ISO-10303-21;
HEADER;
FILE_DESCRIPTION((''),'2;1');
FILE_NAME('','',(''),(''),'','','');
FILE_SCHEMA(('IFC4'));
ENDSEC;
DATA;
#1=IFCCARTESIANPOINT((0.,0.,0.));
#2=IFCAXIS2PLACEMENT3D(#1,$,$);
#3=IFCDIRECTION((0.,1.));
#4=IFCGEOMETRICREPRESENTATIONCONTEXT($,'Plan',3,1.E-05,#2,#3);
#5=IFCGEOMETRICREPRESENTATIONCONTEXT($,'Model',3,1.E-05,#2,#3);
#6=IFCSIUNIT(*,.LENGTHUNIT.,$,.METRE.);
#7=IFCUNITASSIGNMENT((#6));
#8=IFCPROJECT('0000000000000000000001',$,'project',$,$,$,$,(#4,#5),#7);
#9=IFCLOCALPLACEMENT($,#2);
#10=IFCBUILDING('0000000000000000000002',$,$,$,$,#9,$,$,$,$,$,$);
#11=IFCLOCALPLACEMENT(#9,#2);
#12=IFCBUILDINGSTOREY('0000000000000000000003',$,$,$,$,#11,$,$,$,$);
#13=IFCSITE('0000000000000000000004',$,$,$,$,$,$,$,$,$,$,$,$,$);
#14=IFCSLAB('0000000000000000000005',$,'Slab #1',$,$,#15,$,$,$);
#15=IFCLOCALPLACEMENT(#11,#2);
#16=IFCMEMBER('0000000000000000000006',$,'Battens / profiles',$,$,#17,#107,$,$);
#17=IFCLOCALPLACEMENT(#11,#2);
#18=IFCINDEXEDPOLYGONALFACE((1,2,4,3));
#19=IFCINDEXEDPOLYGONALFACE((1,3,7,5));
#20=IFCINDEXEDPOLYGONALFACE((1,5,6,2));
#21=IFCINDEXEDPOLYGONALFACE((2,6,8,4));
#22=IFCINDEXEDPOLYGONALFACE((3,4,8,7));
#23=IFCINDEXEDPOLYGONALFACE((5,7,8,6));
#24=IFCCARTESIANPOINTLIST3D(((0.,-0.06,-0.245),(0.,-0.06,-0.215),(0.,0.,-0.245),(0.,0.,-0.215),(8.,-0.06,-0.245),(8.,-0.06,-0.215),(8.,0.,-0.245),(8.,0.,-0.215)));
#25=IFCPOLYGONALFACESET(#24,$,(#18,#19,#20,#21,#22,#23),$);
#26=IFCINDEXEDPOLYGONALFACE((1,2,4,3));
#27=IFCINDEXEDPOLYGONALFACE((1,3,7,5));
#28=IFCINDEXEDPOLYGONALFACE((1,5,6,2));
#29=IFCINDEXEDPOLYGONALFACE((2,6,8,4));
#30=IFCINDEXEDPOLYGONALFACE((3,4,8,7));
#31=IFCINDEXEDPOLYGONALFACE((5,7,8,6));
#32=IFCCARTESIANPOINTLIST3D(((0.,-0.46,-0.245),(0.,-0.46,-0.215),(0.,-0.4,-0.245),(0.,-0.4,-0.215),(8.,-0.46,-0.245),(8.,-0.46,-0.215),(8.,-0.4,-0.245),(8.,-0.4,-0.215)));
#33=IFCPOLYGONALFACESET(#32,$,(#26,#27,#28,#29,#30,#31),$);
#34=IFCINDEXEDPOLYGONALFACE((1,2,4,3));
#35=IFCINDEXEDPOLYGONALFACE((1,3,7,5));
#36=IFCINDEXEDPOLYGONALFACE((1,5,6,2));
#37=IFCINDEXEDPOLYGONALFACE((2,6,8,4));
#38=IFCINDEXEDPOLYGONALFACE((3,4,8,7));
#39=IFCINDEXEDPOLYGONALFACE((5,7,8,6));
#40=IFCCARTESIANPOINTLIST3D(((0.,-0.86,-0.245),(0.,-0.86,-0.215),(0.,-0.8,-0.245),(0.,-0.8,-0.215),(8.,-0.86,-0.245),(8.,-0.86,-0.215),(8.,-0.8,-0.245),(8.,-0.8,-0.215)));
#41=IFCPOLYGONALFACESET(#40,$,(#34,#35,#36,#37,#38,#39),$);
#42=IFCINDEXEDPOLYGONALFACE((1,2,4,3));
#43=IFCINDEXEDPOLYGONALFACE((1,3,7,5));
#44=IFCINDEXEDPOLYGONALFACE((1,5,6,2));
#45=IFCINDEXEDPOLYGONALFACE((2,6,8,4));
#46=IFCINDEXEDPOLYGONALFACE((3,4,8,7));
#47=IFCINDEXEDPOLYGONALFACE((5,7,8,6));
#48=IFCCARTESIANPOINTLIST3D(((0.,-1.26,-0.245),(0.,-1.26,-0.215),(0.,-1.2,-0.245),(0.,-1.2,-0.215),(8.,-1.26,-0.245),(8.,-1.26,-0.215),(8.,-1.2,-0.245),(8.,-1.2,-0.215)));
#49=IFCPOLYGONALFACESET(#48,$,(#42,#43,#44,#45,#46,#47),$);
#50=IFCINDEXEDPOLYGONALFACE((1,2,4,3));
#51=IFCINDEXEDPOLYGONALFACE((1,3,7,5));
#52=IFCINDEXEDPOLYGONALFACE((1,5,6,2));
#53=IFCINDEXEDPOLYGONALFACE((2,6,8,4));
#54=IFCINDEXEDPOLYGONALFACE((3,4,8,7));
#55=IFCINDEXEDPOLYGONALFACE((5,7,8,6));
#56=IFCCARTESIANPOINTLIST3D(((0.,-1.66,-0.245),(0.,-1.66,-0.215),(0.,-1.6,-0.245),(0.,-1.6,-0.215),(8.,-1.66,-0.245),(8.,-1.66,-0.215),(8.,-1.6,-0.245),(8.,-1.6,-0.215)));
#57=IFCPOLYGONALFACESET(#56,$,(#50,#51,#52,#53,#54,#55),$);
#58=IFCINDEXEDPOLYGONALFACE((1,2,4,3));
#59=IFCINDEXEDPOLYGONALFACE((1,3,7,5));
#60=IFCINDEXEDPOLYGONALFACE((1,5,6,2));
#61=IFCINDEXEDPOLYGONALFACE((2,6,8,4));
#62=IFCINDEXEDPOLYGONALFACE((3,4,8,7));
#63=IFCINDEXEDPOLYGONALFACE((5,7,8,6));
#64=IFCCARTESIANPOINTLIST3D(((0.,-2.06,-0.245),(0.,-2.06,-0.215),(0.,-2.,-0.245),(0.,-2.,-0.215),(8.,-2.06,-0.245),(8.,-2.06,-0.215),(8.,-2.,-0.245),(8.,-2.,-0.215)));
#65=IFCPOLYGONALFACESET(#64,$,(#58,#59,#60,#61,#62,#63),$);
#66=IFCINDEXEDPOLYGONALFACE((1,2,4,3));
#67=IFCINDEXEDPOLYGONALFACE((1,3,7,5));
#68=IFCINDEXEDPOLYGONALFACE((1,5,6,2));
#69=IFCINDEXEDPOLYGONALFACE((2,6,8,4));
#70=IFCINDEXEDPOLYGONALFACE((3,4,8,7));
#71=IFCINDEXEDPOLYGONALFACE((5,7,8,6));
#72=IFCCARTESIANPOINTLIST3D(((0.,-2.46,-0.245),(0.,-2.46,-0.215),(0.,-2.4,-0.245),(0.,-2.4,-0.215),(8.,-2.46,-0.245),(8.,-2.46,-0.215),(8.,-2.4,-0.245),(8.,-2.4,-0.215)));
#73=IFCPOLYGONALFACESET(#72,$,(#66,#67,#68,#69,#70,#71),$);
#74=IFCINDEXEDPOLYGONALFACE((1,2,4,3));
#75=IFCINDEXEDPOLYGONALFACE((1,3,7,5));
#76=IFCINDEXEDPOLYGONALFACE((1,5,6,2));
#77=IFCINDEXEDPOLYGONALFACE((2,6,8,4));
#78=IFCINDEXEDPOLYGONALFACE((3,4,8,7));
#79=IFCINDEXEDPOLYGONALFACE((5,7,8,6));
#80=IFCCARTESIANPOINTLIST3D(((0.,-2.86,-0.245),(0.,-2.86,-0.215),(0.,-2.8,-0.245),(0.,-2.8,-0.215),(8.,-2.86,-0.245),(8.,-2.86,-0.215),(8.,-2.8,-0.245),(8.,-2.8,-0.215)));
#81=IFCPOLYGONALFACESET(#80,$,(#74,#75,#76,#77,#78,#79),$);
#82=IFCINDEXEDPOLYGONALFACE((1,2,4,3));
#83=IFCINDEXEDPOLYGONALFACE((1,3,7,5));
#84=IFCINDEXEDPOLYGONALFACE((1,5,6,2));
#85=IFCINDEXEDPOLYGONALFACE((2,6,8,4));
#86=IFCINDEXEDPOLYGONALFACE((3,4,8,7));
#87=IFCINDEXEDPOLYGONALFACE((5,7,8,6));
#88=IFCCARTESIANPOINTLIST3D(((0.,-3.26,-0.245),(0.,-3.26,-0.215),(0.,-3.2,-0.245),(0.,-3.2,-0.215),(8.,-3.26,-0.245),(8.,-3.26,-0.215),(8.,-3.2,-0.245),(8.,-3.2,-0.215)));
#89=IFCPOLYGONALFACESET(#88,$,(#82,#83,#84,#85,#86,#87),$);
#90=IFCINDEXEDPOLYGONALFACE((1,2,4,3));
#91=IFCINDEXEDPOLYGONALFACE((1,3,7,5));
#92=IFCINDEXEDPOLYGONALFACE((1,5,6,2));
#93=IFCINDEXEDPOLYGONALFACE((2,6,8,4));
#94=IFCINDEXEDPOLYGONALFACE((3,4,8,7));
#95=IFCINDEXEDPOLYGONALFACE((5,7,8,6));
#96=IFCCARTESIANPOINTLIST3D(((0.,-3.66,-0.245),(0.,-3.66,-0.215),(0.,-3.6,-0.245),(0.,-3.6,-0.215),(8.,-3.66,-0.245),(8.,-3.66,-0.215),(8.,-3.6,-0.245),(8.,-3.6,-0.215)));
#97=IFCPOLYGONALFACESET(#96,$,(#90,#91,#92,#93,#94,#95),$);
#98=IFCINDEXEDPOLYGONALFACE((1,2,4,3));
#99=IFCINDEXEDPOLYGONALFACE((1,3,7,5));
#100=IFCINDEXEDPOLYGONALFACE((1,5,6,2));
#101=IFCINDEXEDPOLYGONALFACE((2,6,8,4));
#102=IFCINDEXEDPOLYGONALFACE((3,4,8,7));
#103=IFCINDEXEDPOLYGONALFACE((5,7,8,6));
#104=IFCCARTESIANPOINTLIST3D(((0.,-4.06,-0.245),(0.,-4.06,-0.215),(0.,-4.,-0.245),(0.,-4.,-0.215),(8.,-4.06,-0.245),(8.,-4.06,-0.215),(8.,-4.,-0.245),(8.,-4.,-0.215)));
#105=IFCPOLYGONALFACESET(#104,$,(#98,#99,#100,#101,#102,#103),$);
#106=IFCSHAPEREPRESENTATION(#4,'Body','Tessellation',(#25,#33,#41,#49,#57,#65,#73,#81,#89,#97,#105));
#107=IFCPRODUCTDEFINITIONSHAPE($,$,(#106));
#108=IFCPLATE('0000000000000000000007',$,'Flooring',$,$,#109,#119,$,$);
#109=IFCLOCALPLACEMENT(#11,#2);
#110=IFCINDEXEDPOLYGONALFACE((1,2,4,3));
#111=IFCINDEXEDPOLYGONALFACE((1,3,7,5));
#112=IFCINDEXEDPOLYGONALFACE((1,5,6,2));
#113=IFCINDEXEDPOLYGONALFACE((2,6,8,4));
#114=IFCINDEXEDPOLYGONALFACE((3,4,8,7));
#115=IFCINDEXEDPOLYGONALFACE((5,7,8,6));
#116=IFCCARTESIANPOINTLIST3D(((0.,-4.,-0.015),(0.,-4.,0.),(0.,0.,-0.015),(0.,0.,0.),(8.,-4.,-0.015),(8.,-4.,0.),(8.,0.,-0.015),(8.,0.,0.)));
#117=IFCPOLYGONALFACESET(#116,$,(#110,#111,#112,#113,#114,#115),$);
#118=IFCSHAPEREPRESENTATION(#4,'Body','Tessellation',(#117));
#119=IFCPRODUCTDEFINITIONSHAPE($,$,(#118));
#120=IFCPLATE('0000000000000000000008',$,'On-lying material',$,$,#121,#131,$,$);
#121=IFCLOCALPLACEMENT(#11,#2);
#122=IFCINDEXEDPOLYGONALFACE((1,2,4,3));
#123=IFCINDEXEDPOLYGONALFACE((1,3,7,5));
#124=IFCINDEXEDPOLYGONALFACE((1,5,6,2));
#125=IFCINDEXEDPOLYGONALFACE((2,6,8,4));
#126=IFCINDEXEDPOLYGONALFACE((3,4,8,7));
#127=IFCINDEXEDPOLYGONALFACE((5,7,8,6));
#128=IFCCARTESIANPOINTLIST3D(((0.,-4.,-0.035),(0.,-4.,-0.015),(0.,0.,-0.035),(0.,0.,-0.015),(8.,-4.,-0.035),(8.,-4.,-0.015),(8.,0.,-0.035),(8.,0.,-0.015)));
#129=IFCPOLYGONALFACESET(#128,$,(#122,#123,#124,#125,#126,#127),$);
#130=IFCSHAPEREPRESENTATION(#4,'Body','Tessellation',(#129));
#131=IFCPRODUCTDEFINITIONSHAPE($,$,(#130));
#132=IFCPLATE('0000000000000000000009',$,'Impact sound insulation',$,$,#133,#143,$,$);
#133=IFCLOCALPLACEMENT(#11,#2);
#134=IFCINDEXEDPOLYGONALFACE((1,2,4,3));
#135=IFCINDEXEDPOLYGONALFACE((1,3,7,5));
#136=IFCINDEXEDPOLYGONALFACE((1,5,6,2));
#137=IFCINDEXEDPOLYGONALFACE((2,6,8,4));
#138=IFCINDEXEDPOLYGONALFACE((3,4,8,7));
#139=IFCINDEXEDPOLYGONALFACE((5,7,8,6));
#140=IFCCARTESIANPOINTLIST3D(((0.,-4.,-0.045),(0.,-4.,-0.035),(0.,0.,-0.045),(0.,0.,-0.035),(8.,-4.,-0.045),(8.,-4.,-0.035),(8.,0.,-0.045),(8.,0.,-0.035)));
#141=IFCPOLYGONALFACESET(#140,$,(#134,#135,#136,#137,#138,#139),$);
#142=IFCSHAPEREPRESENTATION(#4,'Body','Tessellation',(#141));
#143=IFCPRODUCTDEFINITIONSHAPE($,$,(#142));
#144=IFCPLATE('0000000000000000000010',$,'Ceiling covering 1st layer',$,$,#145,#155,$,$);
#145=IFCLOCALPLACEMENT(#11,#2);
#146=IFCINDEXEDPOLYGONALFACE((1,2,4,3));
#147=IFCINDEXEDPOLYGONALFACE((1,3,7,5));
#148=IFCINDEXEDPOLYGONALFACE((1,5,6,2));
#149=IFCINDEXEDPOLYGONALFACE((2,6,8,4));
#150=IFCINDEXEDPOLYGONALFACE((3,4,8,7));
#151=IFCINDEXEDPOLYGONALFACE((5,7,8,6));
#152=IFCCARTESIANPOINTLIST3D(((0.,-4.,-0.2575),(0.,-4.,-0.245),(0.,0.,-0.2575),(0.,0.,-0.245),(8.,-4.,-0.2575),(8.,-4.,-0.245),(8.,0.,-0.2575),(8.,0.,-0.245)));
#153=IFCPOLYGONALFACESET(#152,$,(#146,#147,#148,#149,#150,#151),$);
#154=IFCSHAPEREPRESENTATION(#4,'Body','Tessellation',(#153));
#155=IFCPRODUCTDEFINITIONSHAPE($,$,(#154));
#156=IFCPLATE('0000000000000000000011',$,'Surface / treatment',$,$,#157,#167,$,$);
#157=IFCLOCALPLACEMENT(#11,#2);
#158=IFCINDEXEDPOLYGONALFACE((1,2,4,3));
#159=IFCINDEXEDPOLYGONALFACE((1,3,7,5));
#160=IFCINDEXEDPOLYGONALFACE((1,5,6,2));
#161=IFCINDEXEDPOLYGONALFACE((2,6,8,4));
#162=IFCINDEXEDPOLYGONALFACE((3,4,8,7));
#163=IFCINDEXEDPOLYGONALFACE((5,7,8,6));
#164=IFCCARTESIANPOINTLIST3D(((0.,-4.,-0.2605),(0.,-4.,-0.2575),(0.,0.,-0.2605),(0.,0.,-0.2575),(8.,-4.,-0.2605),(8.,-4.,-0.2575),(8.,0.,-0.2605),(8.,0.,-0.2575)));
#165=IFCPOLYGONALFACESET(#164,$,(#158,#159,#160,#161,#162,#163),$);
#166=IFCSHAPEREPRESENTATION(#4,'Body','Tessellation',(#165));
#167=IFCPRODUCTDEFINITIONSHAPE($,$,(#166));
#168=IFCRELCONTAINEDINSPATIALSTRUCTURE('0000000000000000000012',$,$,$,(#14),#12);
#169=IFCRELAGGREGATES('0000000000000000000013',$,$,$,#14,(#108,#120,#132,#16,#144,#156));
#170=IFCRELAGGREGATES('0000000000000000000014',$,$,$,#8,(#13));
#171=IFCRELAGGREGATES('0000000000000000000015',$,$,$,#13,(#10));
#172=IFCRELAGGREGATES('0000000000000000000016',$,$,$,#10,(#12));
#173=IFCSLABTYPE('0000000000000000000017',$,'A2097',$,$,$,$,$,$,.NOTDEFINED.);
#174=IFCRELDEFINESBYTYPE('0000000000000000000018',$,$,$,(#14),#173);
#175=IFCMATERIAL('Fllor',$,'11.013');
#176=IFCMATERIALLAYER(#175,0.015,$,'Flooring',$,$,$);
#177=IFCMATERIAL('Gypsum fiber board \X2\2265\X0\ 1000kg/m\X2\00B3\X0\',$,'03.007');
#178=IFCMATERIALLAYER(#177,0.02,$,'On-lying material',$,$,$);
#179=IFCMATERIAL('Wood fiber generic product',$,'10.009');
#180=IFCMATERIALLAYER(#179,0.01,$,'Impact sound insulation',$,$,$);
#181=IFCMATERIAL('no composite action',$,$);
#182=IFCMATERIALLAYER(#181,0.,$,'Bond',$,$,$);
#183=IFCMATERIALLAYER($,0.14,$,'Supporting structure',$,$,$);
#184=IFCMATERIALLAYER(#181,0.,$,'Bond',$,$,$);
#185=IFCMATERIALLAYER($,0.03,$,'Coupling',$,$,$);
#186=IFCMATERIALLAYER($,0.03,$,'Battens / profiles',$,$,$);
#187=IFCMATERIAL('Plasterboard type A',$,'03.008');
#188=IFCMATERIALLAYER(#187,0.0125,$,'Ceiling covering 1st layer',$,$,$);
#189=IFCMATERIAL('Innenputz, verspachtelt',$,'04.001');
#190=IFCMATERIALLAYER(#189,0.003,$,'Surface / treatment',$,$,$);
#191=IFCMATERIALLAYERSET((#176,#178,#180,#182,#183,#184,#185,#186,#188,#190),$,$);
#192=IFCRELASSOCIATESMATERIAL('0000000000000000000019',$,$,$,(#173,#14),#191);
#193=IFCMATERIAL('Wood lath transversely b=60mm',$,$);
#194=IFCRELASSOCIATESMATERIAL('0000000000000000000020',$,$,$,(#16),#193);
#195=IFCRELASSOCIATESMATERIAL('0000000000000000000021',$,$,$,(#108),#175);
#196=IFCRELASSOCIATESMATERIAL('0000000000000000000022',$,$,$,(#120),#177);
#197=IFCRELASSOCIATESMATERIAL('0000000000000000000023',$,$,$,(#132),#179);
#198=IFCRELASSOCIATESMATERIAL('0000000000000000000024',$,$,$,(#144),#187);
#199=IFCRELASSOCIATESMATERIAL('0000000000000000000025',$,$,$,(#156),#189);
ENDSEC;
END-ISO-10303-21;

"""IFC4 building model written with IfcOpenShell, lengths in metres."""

from ifc_helpers import new_model, si_unit, direction, frame, frame_2d, origin, origin_with_axes, place, context, project, spatial, rectangle, extrude, material, layer, layer_set, type_object, element, aggregate, save


model = new_model("IFC4")

# Units and contexts
plan_context = context("Plan", 3, precision=1e-05, world=origin(), true_north=direction((0.0, 1.0)))
model_context = context("Model", 3, precision=1e-05, world=origin(), true_north=direction((0.0, 1.0)))
ifc_project = project(units=[si_unit("LENGTHUNIT", "METRE")], contexts=[plan_context, model_context])

# Site, building, storey
site = spatial("IfcSite", under=ifc_project)
building_placement = place(None, origin())
building = spatial("IfcBuilding", under=site, at=building_placement)
storey_placement = place(building_placement, origin())
storey = spatial("IfcBuildingStorey", under=building, at=storey_placement)

# Slab, member, plates
ifc_material_1 = material(Name="Fllor", Category="11.013")
ifc_layer_1 = layer(ifc_material_1, 0.015, Name="Flooring")
ifc_material_2 = material(Name="Gypsum fiber board ≥ 1000kg/m³", Category="03.007")
ifc_layer_2 = layer(ifc_material_2, 0.02, Name="On-lying material")
ifc_material_3 = material(Name="Wood fiber generic product", Category="10.009")
ifc_layer_3 = layer(ifc_material_3, 0.01, Name="Impact sound insulation")
ifc_material_4 = material(Name="no composite action")
ifc_layer_4 = layer(ifc_material_4, 0.0, Name="Bond")
ifc_layer_5 = layer(None, 0.14, Name="Supporting structure")
ifc_layer_6 = layer(ifc_material_4, 0.0, Name="Bond")
ifc_layer_7 = layer(None, 0.03, Name="Coupling")
ifc_layer_8 = layer(None, 0.03, Name="Battens / profiles")
ifc_material_5 = material(Name="Plasterboard type A", Category="03.008")
ifc_layer_9 = layer(ifc_material_5, 0.0125, Name="Ceiling covering 1st layer")
ifc_material_6 = material(Name="Innenputz, verspachtelt", Category="04.001")
ifc_layer_10 = layer(ifc_material_6, 0.003, Name="Surface / treatment")
ifc_layer_set = layer_set([ifc_layer_1, ifc_layer_2, ifc_layer_3, ifc_layer_4, ifc_layer_5, ifc_layer_6, ifc_layer_7, ifc_layer_8, ifc_layer_9, ifc_layer_10])
slab_type = type_object("IfcSlabType", Name="A2097", PredefinedType="NOTDEFINED", material=ifc_layer_set)
slab_placement = place(None, frame((0.0, 0.0, 0.0), z_axis=(0.0, 0.0, -1.0), x_axis=(1.0, 0.0, 0.0)))
slab = element("IfcSlab", 1, at=slab_placement, inside=storey, type_object=slab_type, material=ifc_layer_set, Name="Slab #1")
ifc_material_7 = material(Name="Wood lath transversely b=60mm")
member_1_placement = place(slab_placement, origin())
member_1 = element("IfcMember", 2, at=member_1_placement, material=ifc_material_7, Name="Battens / profiles", context=plan_context, shape_type="SweptSolid", body=[
    extrude(rectangle(XDim=0.06, YDim=0.03, at=frame_2d((0.03, 0.015), x_axis=(1.0, 0.0))), frame((0.0, 0.0, 0.215), z_axis=(1.0, 0.0, 0.0), x_axis=(0.0, 1.0, 0.0)), (0.0, 0.0, 1.0), 8.0),
    extrude(rectangle(XDim=0.06, YDim=0.03, at=frame_2d((0.03, 0.015), x_axis=(1.0, 0.0))), frame((0.0, 0.4, 0.215), z_axis=(1.0, 0.0, 0.0), x_axis=(0.0, 1.0, 0.0)), (0.0, 0.0, 1.0), 8.0),
    extrude(rectangle(XDim=0.06, YDim=0.03, at=frame_2d((0.03, 0.015), x_axis=(1.0, 0.0))), frame((0.0, 0.8, 0.215), z_axis=(1.0, 0.0, 0.0), x_axis=(0.0, 1.0, 0.0)), (0.0, 0.0, 1.0), 8.0),
    extrude(rectangle(XDim=0.06, YDim=0.03, at=frame_2d((0.03, 0.015), x_axis=(1.0, 0.0))), frame((0.0, 1.2, 0.215), z_axis=(1.0, 0.0, 0.0), x_axis=(0.0, 1.0, 0.0)), (0.0, 0.0, 1.0), 8.0),
    extrude(rectangle(XDim=0.06, YDim=0.03, at=frame_2d((0.03, 0.015), x_axis=(1.0, 0.0))), frame((0.0, 1.6, 0.215), z_axis=(1.0, 0.0, 0.0), x_axis=(0.0, 1.0, 0.0)), (0.0, 0.0, 1.0), 8.0),
    extrude(rectangle(XDim=0.06, YDim=0.03, at=frame_2d((0.03, 0.015), x_axis=(1.0, 0.0))), frame((0.0, 2.0, 0.215), z_axis=(1.0, 0.0, 0.0), x_axis=(0.0, 1.0, 0.0)), (0.0, 0.0, 1.0), 8.0),
    extrude(rectangle(XDim=0.06, YDim=0.03, at=frame_2d((0.03, 0.015), x_axis=(1.0, 0.0))), frame((0.0, 2.4, 0.215), z_axis=(1.0, 0.0, 0.0), x_axis=(0.0, 1.0, 0.0)), (0.0, 0.0, 1.0), 8.0),
    extrude(rectangle(XDim=0.06, YDim=0.03, at=frame_2d((0.03, 0.015), x_axis=(1.0, 0.0))), frame((0.0, 2.8, 0.215), z_axis=(1.0, 0.0, 0.0), x_axis=(0.0, 1.0, 0.0)), (0.0, 0.0, 1.0), 8.0),
    extrude(rectangle(XDim=0.06, YDim=0.03, at=frame_2d((0.03, 0.015), x_axis=(1.0, 0.0))), frame((0.0, 3.2, 0.215), z_axis=(1.0, 0.0, 0.0), x_axis=(0.0, 1.0, 0.0)), (0.0, 0.0, 1.0), 8.0),
    extrude(rectangle(XDim=0.06, YDim=0.03, at=frame_2d((0.03, 0.015), x_axis=(1.0, 0.0))), frame((0.0, 3.6, 0.215), z_axis=(1.0, 0.0, 0.0), x_axis=(0.0, 1.0, 0.0)), (0.0, 0.0, 1.0), 8.0),
    extrude(rectangle(XDim=0.06, YDim=0.03, at=frame_2d((0.03, 0.015), x_axis=(1.0, 0.0))), frame((0.0, 4.0, 0.215), z_axis=(1.0, 0.0, 0.0), x_axis=(0.0, 1.0, 0.0)), (0.0, 0.0, 1.0), 8.0),
])
plate_1_placement = place(slab_placement, origin())
plate_1 = element("IfcPlate", 3, at=plate_1_placement, material=ifc_material_1, Name="Flooring", context=plan_context, shape_type="SweptSolid", body=[
    extrude(rectangle(XDim=8.0, YDim=4.0, at=frame_2d((4.0, 2.0), x_axis=(1.0, 0.0))), origin_with_axes(), (0.0, 0.0, 1.0), 0.015),
])
plate_2_placement = place(slab_placement, origin())
plate_2 = element("IfcPlate", 4, at=plate_2_placement, material=ifc_material_2, Name="On-lying material", context=plan_context, shape_type="SweptSolid", body=[
    extrude(rectangle(XDim=8.0, YDim=4.0, at=frame_2d((4.0, 2.0), x_axis=(1.0, 0.0))), frame((0.0, 0.0, 0.015), z_axis=(0.0, 0.0, 1.0), x_axis=(1.0, 0.0, 0.0)), (0.0, 0.0, 1.0), 0.02),
])
plate_3_placement = place(slab_placement, origin())
plate_3 = element("IfcPlate", 5, at=plate_3_placement, material=ifc_material_3, Name="Impact sound insulation", context=plan_context, shape_type="SweptSolid", body=[
    extrude(rectangle(XDim=8.0, YDim=4.0, at=frame_2d((4.0, 2.0), x_axis=(1.0, 0.0))), frame((0.0, 0.0, 0.035), z_axis=(0.0, 0.0, 1.0), x_axis=(1.0, 0.0, 0.0)), (0.0, 0.0, 1.0), 0.01),
])
plate_4_placement = place(slab_placement, origin())
plate_4 = element("IfcPlate", 6, at=plate_4_placement, material=ifc_material_5, Name="Ceiling covering 1st layer", context=plan_context, shape_type="SweptSolid", body=[
    extrude(rectangle(XDim=8.0, YDim=4.0, at=frame_2d((4.0, 2.0), x_axis=(1.0, 0.0))), frame((0.0, 0.0, 0.245), z_axis=(0.0, 0.0, 1.0), x_axis=(1.0, 0.0, 0.0)), (0.0, 0.0, 1.0), 0.0125),
])
plate_5_placement = place(slab_placement, origin())
plate_5 = element("IfcPlate", 7, at=plate_5_placement, material=ifc_material_6, Name="Surface / treatment", context=plan_context, shape_type="SweptSolid", body=[
    extrude(rectangle(XDim=8.0, YDim=4.0, at=frame_2d((4.0, 2.0), x_axis=(1.0, 0.0))), frame((0.0, 0.0, 0.2575), z_axis=(0.0, 0.0, 1.0), x_axis=(1.0, 0.0, 0.0)), (0.0, 0.0, 1.0), 0.003),
])
aggregate(slab, [plate_1, plate_2, plate_3, member_1, plate_4, plate_5])

save(model, "model.ifc")
